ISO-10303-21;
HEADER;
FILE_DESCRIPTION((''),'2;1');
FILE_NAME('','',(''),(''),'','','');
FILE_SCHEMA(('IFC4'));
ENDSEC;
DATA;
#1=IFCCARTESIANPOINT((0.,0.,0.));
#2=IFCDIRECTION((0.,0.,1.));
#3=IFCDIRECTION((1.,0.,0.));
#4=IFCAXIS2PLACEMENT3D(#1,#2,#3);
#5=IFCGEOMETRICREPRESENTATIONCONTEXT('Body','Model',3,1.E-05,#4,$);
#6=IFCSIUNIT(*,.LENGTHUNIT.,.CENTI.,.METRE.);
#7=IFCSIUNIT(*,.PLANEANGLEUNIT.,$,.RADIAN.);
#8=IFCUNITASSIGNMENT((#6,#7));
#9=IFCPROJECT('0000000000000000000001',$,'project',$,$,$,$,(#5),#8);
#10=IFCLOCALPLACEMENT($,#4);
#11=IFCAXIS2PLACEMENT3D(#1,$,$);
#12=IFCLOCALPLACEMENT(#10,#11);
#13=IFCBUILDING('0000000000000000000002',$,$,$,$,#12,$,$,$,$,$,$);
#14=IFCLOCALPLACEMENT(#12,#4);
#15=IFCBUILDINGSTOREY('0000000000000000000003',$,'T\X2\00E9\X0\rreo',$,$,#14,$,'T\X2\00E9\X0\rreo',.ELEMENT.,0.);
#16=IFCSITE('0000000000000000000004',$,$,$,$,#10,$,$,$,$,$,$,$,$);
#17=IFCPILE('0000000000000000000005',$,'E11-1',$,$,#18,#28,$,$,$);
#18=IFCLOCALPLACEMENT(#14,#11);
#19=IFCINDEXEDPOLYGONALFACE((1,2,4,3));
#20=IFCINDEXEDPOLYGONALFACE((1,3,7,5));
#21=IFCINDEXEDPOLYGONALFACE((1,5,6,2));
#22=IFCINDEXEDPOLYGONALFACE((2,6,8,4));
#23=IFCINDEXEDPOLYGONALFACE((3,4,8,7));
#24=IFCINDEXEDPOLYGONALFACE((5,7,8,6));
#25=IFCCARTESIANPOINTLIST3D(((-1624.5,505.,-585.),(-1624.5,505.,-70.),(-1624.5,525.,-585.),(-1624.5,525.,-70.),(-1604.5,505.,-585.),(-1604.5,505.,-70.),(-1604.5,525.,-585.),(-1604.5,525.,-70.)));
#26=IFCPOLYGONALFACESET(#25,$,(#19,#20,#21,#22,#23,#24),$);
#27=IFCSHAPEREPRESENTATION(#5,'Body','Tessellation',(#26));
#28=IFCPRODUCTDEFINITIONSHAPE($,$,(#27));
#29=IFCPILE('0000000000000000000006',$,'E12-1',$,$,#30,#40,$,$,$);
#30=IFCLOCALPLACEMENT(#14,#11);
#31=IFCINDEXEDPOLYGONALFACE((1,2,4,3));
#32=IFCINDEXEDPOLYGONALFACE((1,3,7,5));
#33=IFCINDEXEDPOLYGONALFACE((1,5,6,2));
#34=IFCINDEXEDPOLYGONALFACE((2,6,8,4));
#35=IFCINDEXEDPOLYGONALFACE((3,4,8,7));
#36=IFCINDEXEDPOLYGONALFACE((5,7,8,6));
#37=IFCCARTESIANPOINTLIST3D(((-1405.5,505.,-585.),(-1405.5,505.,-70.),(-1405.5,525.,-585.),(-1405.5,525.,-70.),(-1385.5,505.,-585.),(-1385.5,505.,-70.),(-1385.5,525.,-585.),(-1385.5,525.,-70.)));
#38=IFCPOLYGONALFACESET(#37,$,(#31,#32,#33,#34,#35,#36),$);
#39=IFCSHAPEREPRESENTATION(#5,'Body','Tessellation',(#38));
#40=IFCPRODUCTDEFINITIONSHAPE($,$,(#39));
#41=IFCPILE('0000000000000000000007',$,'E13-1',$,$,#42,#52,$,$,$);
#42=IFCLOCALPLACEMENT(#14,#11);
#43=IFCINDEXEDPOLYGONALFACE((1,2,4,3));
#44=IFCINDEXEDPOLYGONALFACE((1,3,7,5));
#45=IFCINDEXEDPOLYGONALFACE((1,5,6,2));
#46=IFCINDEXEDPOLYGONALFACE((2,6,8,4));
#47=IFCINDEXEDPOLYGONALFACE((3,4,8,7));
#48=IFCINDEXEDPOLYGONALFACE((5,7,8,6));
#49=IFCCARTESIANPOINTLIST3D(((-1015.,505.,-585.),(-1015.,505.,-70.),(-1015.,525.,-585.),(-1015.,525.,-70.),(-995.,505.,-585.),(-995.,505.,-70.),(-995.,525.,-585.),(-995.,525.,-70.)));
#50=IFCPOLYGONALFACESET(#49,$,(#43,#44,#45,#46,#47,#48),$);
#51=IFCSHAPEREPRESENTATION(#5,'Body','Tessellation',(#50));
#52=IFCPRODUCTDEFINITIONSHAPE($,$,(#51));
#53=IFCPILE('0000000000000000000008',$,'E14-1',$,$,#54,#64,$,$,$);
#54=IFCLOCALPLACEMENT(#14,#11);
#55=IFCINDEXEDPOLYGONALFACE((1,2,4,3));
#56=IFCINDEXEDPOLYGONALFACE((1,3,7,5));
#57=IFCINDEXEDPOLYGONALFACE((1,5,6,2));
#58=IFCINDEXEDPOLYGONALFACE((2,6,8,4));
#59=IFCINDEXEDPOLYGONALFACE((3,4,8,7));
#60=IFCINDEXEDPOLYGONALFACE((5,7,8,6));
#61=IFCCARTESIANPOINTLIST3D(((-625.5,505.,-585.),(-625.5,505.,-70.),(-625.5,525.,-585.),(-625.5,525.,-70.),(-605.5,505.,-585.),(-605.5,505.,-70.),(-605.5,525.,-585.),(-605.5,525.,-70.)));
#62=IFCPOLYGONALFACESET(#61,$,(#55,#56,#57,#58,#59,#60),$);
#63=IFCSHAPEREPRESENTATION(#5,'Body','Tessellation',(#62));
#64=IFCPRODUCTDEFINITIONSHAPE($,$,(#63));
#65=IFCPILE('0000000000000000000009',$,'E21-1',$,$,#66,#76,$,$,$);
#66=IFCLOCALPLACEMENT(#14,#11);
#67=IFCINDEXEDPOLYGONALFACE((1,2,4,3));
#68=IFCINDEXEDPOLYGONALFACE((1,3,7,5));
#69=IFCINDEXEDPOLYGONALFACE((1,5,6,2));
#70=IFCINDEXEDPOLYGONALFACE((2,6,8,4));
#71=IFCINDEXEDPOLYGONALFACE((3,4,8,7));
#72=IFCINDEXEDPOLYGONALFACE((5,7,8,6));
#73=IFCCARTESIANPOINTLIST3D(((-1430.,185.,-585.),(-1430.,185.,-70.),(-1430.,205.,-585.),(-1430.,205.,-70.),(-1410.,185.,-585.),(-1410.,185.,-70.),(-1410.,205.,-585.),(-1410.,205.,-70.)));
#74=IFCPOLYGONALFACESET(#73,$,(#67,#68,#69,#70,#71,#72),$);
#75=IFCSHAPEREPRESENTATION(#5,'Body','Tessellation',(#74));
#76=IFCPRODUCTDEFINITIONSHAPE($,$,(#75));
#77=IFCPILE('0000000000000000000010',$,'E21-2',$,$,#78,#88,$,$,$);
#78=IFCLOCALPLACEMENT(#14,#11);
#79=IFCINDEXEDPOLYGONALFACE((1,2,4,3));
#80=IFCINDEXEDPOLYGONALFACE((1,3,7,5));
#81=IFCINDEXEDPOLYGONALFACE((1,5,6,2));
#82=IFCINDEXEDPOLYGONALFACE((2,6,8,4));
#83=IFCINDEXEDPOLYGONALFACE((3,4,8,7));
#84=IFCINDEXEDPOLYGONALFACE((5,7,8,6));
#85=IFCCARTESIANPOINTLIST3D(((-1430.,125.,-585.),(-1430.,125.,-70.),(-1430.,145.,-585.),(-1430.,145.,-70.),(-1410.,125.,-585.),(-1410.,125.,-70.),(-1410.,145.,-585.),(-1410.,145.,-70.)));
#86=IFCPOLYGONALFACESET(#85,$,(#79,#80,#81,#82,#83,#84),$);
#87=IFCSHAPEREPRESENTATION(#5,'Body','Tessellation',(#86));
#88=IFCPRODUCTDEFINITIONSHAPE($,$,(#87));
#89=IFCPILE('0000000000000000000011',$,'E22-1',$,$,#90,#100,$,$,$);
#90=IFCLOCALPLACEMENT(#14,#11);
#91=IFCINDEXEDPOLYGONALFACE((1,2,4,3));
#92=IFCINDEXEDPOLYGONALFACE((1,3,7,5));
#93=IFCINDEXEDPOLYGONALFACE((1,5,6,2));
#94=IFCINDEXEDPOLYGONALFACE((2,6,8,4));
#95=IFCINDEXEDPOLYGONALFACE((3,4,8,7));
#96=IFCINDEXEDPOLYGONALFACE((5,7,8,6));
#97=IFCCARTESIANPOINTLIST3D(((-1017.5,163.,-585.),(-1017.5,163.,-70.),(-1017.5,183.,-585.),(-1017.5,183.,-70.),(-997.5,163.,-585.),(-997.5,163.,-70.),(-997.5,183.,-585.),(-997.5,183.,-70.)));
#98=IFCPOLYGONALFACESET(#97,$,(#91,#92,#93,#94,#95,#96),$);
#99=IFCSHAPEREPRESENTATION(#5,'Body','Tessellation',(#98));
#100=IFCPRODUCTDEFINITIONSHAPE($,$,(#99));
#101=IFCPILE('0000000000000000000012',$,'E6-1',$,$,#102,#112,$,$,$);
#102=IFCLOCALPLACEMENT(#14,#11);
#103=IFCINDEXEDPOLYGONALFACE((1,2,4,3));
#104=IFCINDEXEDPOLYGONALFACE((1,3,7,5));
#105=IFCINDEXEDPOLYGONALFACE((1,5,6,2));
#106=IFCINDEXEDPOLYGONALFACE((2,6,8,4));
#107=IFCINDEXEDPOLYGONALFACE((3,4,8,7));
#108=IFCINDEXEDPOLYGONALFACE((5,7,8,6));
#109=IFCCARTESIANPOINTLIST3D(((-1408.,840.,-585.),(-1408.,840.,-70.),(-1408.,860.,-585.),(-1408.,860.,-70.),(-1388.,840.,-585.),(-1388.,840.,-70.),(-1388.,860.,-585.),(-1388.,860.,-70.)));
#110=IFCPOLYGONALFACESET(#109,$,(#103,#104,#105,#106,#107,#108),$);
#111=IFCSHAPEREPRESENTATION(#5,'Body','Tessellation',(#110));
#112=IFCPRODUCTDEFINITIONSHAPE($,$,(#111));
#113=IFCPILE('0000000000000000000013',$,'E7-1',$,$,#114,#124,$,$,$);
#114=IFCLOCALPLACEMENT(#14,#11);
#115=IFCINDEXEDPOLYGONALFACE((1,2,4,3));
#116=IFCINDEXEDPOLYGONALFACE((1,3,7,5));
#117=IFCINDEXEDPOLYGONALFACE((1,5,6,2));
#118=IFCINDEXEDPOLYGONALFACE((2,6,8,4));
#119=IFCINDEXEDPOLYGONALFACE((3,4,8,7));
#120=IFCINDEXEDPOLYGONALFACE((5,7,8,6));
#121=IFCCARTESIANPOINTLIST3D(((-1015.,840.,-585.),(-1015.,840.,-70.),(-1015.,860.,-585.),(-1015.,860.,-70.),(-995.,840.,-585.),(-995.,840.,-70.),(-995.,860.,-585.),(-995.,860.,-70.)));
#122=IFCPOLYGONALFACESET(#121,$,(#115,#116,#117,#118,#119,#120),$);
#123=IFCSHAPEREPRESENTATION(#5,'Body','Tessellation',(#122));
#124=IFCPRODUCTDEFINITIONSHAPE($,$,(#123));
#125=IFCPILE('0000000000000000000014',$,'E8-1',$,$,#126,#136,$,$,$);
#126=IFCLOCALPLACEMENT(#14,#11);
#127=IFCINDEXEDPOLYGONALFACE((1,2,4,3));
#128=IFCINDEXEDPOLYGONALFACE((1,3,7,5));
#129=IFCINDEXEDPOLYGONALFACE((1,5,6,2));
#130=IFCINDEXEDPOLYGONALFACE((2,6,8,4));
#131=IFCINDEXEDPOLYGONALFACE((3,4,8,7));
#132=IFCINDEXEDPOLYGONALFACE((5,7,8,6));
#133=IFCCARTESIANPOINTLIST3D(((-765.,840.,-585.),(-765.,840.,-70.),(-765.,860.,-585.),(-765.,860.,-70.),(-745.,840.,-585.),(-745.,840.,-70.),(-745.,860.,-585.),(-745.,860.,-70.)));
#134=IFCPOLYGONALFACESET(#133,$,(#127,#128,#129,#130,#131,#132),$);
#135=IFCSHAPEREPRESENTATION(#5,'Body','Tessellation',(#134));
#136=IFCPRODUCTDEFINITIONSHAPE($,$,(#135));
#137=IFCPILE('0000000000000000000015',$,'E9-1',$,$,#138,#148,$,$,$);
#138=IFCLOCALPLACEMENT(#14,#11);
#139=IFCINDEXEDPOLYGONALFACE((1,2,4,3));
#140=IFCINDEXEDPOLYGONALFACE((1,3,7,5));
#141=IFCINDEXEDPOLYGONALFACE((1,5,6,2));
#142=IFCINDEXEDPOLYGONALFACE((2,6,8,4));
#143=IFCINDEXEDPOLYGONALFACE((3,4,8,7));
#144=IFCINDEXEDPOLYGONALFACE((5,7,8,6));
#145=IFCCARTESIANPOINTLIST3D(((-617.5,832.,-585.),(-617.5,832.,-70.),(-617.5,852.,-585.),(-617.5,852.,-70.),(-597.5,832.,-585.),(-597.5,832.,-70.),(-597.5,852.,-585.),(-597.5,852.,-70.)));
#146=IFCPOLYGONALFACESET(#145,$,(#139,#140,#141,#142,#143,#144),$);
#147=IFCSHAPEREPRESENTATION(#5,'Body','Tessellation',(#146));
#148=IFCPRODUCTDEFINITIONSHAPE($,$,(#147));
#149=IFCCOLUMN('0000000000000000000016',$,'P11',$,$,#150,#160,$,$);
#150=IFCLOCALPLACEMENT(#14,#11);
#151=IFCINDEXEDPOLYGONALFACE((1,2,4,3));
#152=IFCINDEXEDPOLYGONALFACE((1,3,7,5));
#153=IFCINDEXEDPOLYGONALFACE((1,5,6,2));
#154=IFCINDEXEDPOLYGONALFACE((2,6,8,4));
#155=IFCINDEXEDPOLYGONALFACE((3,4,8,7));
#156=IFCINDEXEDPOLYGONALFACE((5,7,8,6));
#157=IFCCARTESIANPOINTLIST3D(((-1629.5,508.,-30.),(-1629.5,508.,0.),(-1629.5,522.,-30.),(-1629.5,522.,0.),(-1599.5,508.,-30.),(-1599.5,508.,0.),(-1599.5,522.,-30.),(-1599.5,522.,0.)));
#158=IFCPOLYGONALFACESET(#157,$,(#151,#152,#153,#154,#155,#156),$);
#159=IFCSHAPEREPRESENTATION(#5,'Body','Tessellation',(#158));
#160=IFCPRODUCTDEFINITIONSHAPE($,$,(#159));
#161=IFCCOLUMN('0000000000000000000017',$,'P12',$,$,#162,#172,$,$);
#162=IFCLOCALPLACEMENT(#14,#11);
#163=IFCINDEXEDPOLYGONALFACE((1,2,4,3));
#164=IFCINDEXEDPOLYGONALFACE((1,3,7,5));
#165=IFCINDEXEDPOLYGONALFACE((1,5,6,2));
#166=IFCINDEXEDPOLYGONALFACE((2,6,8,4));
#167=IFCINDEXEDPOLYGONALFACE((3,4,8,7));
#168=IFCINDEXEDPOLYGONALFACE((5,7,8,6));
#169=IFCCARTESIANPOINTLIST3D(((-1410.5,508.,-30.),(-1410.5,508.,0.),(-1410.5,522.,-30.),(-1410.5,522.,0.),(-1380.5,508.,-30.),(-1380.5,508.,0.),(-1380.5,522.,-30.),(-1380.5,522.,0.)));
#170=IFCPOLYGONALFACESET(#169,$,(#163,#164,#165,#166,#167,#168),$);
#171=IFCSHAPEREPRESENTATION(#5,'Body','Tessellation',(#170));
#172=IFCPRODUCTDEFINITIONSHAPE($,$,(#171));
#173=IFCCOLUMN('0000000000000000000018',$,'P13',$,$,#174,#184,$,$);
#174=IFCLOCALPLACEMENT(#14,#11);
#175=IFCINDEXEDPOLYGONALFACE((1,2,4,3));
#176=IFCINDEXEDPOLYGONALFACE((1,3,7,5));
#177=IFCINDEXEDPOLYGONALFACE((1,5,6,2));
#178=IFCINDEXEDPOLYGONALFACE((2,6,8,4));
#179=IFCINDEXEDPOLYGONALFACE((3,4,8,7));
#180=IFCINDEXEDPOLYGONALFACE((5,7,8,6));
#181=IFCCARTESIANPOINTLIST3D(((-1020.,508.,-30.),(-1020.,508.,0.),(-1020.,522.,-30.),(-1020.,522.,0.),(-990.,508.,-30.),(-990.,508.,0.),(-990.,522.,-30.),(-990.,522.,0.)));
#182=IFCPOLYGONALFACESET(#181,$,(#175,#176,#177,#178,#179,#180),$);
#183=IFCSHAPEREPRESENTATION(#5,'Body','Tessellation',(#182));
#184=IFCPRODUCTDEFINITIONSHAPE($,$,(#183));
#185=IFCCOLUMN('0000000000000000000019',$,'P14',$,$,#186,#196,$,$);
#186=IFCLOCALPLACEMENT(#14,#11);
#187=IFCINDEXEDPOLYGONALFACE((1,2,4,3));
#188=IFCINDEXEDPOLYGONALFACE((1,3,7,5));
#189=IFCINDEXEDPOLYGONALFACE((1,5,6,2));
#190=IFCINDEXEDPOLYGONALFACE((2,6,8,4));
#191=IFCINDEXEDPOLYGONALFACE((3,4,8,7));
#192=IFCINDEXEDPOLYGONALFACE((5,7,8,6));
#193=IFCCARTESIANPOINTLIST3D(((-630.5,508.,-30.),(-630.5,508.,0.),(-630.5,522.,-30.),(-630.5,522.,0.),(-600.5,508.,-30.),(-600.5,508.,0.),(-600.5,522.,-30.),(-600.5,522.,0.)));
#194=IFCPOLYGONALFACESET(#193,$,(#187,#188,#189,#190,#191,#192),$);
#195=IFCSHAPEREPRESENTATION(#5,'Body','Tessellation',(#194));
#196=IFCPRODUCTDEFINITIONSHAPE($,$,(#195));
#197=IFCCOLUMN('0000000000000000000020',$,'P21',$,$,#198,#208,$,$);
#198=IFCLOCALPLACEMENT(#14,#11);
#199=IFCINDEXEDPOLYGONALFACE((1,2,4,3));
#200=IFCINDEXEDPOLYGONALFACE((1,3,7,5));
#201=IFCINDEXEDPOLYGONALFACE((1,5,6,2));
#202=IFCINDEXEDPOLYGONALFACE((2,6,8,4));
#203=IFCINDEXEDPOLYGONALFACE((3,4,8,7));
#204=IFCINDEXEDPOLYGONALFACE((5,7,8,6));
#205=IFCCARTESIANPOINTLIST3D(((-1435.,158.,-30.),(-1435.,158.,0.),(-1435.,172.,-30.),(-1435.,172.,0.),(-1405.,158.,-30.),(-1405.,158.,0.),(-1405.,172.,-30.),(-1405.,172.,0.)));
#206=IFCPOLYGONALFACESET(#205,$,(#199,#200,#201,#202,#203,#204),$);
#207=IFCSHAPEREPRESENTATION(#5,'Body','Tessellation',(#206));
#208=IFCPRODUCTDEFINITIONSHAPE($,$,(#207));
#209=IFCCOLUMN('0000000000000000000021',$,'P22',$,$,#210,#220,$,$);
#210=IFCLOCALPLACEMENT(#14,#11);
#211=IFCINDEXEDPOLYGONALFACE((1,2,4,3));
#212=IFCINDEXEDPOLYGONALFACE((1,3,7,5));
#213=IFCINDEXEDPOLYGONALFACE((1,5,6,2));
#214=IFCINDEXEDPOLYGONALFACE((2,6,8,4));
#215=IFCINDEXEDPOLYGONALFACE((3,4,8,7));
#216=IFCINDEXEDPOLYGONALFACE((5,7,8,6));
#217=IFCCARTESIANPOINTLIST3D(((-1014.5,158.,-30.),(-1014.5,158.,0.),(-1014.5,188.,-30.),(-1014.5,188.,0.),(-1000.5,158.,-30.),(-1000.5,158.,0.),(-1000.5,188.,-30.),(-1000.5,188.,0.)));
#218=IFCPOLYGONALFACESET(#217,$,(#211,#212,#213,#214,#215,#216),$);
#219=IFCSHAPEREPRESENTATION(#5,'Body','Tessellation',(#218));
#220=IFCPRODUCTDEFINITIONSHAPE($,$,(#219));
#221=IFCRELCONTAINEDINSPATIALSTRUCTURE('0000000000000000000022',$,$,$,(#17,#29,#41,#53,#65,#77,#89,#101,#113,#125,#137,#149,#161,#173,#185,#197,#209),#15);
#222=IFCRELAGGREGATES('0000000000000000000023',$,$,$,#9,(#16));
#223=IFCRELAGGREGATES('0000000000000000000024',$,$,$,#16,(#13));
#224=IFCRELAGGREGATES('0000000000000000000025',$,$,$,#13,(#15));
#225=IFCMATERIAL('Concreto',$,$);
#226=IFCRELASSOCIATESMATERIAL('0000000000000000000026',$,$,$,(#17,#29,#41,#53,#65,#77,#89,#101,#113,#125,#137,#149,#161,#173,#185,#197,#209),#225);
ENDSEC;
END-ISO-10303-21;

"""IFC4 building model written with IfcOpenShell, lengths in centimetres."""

from ifc_helpers import new_model, si_unit, frame, origin, origin_with_axes, origin_2d_with_axis, place, context, project, spatial, rectangle, extrude, material, element, save


model = new_model("IFC4")

# Units and contexts
model_context = context("Model", 3, precision=1e-05, world=origin_with_axes(), identifier="Body")
ifc_project = project(units=[si_unit("LENGTHUNIT", "METRE", prefix="CENTI"), si_unit("PLANEANGLEUNIT", "RADIAN")], contexts=[model_context])

# Site, building, storey
site_placement = place(None, origin_with_axes())
site = spatial("IfcSite", under=ifc_project, at=site_placement)
building_placement = place(site_placement, origin())
building = spatial("IfcBuilding", under=site, at=building_placement)
storey_placement = place(building_placement, origin_with_axes())
storey = spatial("IfcBuildingStorey", under=building, at=storey_placement, Name="Térreo", LongName="Térreo", CompositionType="ELEMENT", Elevation=0.0)

# Piles
ifc_material = material(Name="Concreto")
for number, where, z_axis, x_axis, name in (
    (1, (-1614.5, 515.0, -70.0), (0.0, 0.0, 1.0), (1.0, 0.0, 0.0), "E11-1"),
    (2, (-1395.5, 515.0, -70.0), (0.0, 0.0, 1.0), (1.0, 0.0, 0.0), "E12-1"),
):
    element("IfcPile", number, at=place(storey_placement, frame(where, z_axis=z_axis, x_axis=x_axis)), inside=storey, material=ifc_material, Name=name, context=model_context, shape_type="SweptSolid", body=[
        extrude(rectangle(XDim=20.0, YDim=20.0, at=origin_2d_with_axis()), frame((0.0, 0.0, -515.0), z_axis=(0.0, 0.0, 1.0), x_axis=(0.0, 1.0, 0.0)), (0.0, 0.0, 1.0), 515.0),
    ])
for number, where, z_axis, x_axis, name in (
    (3, (-1005.0, 515.0, -70.0), (0.0, 0.0, 1.0), (1.0, 0.0, 0.0), "E13-1"),
    (4, (-615.5, 515.0, -70.0), (0.0, 0.0, 1.0), (1.0, 0.0, 0.0), "E14-1"),
    (5, (-1420.0, 195.0, -70.0), (0.0, 0.0, 1.0), (1.0, 0.0, 0.0), "E21-1"),
    (6, (-1420.0, 135.0, -70.0), (0.0, 0.0, 1.0), (1.0, 0.0, 0.0), "E21-2"),
):
    element("IfcPile", number, at=place(storey_placement, frame(where, z_axis=z_axis, x_axis=x_axis)), inside=storey, material=ifc_material, Name=name, context=model_context, shape_type="SweptSolid", body=[
        extrude(rectangle(XDim=20.0, YDim=20.0, at=origin_2d_with_axis()), frame((0.0, 0.0, -515.0), z_axis=(0.0, 0.0, 1.0), x_axis=(0.0, -1.0, 0.0)), (0.0, 0.0, 1.0), 515.0),
    ])
pile_1_placement = place(storey_placement, frame((-1007.5, 173.0, -70.0), z_axis=(0.0, 0.0, 1.0), x_axis=(1.0, 0.0, 0.0)))
element("IfcPile", 7, at=pile_1_placement, inside=storey, material=ifc_material, Name="E22-1", context=model_context, shape_type="SweptSolid", body=[
    extrude(rectangle(XDim=20.0, YDim=20.0, at=origin_2d_with_axis()), frame((0.0, 0.0, -515.0), z_axis=(0.0, 0.0, 1.0), x_axis=(1.0, 0.0, 0.0)), (0.0, 0.0, 1.0), 515.0),
])
for number, where, z_axis, x_axis, name in (
    (8, (-1398.0, 850.0, -70.0), (0.0, 0.0, 1.0), (1.0, 0.0, 0.0), "E6-1"),
    (9, (-1005.0, 850.0, -70.0), (0.0, 0.0, 1.0), (1.0, 0.0, 0.0), "E7-1"),
    (10, (-755.0, 850.0, -70.0), (0.0, 0.0, 1.0), (1.0, 0.0, 0.0), "E8-1"),
):
    element("IfcPile", number, at=place(storey_placement, frame(where, z_axis=z_axis, x_axis=x_axis)), inside=storey, material=ifc_material, Name=name, context=model_context, shape_type="SweptSolid", body=[
        extrude(rectangle(XDim=20.0, YDim=20.0, at=origin_2d_with_axis()), frame((0.0, 0.0, -515.0), z_axis=(0.0, 0.0, 1.0), x_axis=(0.0, 1.0, 0.0)), (0.0, 0.0, 1.0), 515.0),
    ])
pile_2_placement = place(storey_placement, frame((-607.5, 842.0, -70.0), z_axis=(0.0, 0.0, 1.0), x_axis=(1.0, 0.0, 0.0)))
element("IfcPile", 11, at=pile_2_placement, inside=storey, material=ifc_material, Name="E9-1", context=model_context, shape_type="SweptSolid", body=[
    extrude(rectangle(XDim=20.0, YDim=20.0, at=origin_2d_with_axis()), frame((0.0, 0.0, -515.0), z_axis=(0.0, 0.0, 1.0), x_axis=(-1.0, 0.0, 0.0)), (0.0, 0.0, 1.0), 515.0),
])

# Columns
for number, where, z_axis, x_axis, name in (
    (12, (-1614.5, 515.0, 0.0), (0.0, 0.0, 1.0), (1.0, 0.0, 0.0), "P11"),
    (13, (-1395.5, 515.0, 0.0), (0.0, 0.0, 1.0), (1.0, 0.0, 0.0), "P12"),
):
    element("IfcColumn", number, at=place(storey_placement, frame(where, z_axis=z_axis, x_axis=x_axis)), inside=storey, material=ifc_material, Name=name, context=model_context, shape_type="SolidModel", body=[
        extrude(rectangle(XDim=14.0, YDim=30.0, at=origin_2d_with_axis()), frame((0.0, 0.0, -30.0), z_axis=(0.0, 0.0, 1.0), x_axis=(0.0, 1.0, 0.0)), (0.0, 0.0, 1.0), 30.0),
    ])
for number, where, z_axis, x_axis, name in (
    (14, (-1005.0, 515.0, 0.0), (0.0, 0.0, 1.0), (1.0, 0.0, 0.0), "P13"),
    (15, (-615.5, 515.0, 0.0), (0.0, 0.0, 1.0), (1.0, 0.0, 0.0), "P14"),
    (16, (-1420.0, 165.0, 0.0), (0.0, 0.0, 1.0), (1.0, 0.0, 0.0), "P21"),
):
    element("IfcColumn", number, at=place(storey_placement, frame(where, z_axis=z_axis, x_axis=x_axis)), inside=storey, material=ifc_material, Name=name, context=model_context, shape_type="SolidModel", body=[
        extrude(rectangle(XDim=14.0, YDim=30.0, at=origin_2d_with_axis()), frame((0.0, 0.0, -30.0), z_axis=(0.0, 0.0, 1.0), x_axis=(0.0, -1.0, 0.0)), (0.0, 0.0, 1.0), 30.0),
    ])
column_1_placement = place(storey_placement, frame((-1007.5, 173.0, 0.0), z_axis=(0.0, 0.0, 1.0), x_axis=(1.0, 0.0, 0.0)))
element("IfcColumn", 17, at=column_1_placement, inside=storey, material=ifc_material, Name="P22", context=model_context, shape_type="SolidModel", body=[
    extrude(rectangle(XDim=14.0, YDim=30.0, at=origin_2d_with_axis()), frame((0.0, 0.0, -30.0), z_axis=(0.0, 0.0, 1.0), x_axis=(1.0, 0.0, 0.0)), (0.0, 0.0, 1.0), 30.0),
])

save(model, "model.ifc")
